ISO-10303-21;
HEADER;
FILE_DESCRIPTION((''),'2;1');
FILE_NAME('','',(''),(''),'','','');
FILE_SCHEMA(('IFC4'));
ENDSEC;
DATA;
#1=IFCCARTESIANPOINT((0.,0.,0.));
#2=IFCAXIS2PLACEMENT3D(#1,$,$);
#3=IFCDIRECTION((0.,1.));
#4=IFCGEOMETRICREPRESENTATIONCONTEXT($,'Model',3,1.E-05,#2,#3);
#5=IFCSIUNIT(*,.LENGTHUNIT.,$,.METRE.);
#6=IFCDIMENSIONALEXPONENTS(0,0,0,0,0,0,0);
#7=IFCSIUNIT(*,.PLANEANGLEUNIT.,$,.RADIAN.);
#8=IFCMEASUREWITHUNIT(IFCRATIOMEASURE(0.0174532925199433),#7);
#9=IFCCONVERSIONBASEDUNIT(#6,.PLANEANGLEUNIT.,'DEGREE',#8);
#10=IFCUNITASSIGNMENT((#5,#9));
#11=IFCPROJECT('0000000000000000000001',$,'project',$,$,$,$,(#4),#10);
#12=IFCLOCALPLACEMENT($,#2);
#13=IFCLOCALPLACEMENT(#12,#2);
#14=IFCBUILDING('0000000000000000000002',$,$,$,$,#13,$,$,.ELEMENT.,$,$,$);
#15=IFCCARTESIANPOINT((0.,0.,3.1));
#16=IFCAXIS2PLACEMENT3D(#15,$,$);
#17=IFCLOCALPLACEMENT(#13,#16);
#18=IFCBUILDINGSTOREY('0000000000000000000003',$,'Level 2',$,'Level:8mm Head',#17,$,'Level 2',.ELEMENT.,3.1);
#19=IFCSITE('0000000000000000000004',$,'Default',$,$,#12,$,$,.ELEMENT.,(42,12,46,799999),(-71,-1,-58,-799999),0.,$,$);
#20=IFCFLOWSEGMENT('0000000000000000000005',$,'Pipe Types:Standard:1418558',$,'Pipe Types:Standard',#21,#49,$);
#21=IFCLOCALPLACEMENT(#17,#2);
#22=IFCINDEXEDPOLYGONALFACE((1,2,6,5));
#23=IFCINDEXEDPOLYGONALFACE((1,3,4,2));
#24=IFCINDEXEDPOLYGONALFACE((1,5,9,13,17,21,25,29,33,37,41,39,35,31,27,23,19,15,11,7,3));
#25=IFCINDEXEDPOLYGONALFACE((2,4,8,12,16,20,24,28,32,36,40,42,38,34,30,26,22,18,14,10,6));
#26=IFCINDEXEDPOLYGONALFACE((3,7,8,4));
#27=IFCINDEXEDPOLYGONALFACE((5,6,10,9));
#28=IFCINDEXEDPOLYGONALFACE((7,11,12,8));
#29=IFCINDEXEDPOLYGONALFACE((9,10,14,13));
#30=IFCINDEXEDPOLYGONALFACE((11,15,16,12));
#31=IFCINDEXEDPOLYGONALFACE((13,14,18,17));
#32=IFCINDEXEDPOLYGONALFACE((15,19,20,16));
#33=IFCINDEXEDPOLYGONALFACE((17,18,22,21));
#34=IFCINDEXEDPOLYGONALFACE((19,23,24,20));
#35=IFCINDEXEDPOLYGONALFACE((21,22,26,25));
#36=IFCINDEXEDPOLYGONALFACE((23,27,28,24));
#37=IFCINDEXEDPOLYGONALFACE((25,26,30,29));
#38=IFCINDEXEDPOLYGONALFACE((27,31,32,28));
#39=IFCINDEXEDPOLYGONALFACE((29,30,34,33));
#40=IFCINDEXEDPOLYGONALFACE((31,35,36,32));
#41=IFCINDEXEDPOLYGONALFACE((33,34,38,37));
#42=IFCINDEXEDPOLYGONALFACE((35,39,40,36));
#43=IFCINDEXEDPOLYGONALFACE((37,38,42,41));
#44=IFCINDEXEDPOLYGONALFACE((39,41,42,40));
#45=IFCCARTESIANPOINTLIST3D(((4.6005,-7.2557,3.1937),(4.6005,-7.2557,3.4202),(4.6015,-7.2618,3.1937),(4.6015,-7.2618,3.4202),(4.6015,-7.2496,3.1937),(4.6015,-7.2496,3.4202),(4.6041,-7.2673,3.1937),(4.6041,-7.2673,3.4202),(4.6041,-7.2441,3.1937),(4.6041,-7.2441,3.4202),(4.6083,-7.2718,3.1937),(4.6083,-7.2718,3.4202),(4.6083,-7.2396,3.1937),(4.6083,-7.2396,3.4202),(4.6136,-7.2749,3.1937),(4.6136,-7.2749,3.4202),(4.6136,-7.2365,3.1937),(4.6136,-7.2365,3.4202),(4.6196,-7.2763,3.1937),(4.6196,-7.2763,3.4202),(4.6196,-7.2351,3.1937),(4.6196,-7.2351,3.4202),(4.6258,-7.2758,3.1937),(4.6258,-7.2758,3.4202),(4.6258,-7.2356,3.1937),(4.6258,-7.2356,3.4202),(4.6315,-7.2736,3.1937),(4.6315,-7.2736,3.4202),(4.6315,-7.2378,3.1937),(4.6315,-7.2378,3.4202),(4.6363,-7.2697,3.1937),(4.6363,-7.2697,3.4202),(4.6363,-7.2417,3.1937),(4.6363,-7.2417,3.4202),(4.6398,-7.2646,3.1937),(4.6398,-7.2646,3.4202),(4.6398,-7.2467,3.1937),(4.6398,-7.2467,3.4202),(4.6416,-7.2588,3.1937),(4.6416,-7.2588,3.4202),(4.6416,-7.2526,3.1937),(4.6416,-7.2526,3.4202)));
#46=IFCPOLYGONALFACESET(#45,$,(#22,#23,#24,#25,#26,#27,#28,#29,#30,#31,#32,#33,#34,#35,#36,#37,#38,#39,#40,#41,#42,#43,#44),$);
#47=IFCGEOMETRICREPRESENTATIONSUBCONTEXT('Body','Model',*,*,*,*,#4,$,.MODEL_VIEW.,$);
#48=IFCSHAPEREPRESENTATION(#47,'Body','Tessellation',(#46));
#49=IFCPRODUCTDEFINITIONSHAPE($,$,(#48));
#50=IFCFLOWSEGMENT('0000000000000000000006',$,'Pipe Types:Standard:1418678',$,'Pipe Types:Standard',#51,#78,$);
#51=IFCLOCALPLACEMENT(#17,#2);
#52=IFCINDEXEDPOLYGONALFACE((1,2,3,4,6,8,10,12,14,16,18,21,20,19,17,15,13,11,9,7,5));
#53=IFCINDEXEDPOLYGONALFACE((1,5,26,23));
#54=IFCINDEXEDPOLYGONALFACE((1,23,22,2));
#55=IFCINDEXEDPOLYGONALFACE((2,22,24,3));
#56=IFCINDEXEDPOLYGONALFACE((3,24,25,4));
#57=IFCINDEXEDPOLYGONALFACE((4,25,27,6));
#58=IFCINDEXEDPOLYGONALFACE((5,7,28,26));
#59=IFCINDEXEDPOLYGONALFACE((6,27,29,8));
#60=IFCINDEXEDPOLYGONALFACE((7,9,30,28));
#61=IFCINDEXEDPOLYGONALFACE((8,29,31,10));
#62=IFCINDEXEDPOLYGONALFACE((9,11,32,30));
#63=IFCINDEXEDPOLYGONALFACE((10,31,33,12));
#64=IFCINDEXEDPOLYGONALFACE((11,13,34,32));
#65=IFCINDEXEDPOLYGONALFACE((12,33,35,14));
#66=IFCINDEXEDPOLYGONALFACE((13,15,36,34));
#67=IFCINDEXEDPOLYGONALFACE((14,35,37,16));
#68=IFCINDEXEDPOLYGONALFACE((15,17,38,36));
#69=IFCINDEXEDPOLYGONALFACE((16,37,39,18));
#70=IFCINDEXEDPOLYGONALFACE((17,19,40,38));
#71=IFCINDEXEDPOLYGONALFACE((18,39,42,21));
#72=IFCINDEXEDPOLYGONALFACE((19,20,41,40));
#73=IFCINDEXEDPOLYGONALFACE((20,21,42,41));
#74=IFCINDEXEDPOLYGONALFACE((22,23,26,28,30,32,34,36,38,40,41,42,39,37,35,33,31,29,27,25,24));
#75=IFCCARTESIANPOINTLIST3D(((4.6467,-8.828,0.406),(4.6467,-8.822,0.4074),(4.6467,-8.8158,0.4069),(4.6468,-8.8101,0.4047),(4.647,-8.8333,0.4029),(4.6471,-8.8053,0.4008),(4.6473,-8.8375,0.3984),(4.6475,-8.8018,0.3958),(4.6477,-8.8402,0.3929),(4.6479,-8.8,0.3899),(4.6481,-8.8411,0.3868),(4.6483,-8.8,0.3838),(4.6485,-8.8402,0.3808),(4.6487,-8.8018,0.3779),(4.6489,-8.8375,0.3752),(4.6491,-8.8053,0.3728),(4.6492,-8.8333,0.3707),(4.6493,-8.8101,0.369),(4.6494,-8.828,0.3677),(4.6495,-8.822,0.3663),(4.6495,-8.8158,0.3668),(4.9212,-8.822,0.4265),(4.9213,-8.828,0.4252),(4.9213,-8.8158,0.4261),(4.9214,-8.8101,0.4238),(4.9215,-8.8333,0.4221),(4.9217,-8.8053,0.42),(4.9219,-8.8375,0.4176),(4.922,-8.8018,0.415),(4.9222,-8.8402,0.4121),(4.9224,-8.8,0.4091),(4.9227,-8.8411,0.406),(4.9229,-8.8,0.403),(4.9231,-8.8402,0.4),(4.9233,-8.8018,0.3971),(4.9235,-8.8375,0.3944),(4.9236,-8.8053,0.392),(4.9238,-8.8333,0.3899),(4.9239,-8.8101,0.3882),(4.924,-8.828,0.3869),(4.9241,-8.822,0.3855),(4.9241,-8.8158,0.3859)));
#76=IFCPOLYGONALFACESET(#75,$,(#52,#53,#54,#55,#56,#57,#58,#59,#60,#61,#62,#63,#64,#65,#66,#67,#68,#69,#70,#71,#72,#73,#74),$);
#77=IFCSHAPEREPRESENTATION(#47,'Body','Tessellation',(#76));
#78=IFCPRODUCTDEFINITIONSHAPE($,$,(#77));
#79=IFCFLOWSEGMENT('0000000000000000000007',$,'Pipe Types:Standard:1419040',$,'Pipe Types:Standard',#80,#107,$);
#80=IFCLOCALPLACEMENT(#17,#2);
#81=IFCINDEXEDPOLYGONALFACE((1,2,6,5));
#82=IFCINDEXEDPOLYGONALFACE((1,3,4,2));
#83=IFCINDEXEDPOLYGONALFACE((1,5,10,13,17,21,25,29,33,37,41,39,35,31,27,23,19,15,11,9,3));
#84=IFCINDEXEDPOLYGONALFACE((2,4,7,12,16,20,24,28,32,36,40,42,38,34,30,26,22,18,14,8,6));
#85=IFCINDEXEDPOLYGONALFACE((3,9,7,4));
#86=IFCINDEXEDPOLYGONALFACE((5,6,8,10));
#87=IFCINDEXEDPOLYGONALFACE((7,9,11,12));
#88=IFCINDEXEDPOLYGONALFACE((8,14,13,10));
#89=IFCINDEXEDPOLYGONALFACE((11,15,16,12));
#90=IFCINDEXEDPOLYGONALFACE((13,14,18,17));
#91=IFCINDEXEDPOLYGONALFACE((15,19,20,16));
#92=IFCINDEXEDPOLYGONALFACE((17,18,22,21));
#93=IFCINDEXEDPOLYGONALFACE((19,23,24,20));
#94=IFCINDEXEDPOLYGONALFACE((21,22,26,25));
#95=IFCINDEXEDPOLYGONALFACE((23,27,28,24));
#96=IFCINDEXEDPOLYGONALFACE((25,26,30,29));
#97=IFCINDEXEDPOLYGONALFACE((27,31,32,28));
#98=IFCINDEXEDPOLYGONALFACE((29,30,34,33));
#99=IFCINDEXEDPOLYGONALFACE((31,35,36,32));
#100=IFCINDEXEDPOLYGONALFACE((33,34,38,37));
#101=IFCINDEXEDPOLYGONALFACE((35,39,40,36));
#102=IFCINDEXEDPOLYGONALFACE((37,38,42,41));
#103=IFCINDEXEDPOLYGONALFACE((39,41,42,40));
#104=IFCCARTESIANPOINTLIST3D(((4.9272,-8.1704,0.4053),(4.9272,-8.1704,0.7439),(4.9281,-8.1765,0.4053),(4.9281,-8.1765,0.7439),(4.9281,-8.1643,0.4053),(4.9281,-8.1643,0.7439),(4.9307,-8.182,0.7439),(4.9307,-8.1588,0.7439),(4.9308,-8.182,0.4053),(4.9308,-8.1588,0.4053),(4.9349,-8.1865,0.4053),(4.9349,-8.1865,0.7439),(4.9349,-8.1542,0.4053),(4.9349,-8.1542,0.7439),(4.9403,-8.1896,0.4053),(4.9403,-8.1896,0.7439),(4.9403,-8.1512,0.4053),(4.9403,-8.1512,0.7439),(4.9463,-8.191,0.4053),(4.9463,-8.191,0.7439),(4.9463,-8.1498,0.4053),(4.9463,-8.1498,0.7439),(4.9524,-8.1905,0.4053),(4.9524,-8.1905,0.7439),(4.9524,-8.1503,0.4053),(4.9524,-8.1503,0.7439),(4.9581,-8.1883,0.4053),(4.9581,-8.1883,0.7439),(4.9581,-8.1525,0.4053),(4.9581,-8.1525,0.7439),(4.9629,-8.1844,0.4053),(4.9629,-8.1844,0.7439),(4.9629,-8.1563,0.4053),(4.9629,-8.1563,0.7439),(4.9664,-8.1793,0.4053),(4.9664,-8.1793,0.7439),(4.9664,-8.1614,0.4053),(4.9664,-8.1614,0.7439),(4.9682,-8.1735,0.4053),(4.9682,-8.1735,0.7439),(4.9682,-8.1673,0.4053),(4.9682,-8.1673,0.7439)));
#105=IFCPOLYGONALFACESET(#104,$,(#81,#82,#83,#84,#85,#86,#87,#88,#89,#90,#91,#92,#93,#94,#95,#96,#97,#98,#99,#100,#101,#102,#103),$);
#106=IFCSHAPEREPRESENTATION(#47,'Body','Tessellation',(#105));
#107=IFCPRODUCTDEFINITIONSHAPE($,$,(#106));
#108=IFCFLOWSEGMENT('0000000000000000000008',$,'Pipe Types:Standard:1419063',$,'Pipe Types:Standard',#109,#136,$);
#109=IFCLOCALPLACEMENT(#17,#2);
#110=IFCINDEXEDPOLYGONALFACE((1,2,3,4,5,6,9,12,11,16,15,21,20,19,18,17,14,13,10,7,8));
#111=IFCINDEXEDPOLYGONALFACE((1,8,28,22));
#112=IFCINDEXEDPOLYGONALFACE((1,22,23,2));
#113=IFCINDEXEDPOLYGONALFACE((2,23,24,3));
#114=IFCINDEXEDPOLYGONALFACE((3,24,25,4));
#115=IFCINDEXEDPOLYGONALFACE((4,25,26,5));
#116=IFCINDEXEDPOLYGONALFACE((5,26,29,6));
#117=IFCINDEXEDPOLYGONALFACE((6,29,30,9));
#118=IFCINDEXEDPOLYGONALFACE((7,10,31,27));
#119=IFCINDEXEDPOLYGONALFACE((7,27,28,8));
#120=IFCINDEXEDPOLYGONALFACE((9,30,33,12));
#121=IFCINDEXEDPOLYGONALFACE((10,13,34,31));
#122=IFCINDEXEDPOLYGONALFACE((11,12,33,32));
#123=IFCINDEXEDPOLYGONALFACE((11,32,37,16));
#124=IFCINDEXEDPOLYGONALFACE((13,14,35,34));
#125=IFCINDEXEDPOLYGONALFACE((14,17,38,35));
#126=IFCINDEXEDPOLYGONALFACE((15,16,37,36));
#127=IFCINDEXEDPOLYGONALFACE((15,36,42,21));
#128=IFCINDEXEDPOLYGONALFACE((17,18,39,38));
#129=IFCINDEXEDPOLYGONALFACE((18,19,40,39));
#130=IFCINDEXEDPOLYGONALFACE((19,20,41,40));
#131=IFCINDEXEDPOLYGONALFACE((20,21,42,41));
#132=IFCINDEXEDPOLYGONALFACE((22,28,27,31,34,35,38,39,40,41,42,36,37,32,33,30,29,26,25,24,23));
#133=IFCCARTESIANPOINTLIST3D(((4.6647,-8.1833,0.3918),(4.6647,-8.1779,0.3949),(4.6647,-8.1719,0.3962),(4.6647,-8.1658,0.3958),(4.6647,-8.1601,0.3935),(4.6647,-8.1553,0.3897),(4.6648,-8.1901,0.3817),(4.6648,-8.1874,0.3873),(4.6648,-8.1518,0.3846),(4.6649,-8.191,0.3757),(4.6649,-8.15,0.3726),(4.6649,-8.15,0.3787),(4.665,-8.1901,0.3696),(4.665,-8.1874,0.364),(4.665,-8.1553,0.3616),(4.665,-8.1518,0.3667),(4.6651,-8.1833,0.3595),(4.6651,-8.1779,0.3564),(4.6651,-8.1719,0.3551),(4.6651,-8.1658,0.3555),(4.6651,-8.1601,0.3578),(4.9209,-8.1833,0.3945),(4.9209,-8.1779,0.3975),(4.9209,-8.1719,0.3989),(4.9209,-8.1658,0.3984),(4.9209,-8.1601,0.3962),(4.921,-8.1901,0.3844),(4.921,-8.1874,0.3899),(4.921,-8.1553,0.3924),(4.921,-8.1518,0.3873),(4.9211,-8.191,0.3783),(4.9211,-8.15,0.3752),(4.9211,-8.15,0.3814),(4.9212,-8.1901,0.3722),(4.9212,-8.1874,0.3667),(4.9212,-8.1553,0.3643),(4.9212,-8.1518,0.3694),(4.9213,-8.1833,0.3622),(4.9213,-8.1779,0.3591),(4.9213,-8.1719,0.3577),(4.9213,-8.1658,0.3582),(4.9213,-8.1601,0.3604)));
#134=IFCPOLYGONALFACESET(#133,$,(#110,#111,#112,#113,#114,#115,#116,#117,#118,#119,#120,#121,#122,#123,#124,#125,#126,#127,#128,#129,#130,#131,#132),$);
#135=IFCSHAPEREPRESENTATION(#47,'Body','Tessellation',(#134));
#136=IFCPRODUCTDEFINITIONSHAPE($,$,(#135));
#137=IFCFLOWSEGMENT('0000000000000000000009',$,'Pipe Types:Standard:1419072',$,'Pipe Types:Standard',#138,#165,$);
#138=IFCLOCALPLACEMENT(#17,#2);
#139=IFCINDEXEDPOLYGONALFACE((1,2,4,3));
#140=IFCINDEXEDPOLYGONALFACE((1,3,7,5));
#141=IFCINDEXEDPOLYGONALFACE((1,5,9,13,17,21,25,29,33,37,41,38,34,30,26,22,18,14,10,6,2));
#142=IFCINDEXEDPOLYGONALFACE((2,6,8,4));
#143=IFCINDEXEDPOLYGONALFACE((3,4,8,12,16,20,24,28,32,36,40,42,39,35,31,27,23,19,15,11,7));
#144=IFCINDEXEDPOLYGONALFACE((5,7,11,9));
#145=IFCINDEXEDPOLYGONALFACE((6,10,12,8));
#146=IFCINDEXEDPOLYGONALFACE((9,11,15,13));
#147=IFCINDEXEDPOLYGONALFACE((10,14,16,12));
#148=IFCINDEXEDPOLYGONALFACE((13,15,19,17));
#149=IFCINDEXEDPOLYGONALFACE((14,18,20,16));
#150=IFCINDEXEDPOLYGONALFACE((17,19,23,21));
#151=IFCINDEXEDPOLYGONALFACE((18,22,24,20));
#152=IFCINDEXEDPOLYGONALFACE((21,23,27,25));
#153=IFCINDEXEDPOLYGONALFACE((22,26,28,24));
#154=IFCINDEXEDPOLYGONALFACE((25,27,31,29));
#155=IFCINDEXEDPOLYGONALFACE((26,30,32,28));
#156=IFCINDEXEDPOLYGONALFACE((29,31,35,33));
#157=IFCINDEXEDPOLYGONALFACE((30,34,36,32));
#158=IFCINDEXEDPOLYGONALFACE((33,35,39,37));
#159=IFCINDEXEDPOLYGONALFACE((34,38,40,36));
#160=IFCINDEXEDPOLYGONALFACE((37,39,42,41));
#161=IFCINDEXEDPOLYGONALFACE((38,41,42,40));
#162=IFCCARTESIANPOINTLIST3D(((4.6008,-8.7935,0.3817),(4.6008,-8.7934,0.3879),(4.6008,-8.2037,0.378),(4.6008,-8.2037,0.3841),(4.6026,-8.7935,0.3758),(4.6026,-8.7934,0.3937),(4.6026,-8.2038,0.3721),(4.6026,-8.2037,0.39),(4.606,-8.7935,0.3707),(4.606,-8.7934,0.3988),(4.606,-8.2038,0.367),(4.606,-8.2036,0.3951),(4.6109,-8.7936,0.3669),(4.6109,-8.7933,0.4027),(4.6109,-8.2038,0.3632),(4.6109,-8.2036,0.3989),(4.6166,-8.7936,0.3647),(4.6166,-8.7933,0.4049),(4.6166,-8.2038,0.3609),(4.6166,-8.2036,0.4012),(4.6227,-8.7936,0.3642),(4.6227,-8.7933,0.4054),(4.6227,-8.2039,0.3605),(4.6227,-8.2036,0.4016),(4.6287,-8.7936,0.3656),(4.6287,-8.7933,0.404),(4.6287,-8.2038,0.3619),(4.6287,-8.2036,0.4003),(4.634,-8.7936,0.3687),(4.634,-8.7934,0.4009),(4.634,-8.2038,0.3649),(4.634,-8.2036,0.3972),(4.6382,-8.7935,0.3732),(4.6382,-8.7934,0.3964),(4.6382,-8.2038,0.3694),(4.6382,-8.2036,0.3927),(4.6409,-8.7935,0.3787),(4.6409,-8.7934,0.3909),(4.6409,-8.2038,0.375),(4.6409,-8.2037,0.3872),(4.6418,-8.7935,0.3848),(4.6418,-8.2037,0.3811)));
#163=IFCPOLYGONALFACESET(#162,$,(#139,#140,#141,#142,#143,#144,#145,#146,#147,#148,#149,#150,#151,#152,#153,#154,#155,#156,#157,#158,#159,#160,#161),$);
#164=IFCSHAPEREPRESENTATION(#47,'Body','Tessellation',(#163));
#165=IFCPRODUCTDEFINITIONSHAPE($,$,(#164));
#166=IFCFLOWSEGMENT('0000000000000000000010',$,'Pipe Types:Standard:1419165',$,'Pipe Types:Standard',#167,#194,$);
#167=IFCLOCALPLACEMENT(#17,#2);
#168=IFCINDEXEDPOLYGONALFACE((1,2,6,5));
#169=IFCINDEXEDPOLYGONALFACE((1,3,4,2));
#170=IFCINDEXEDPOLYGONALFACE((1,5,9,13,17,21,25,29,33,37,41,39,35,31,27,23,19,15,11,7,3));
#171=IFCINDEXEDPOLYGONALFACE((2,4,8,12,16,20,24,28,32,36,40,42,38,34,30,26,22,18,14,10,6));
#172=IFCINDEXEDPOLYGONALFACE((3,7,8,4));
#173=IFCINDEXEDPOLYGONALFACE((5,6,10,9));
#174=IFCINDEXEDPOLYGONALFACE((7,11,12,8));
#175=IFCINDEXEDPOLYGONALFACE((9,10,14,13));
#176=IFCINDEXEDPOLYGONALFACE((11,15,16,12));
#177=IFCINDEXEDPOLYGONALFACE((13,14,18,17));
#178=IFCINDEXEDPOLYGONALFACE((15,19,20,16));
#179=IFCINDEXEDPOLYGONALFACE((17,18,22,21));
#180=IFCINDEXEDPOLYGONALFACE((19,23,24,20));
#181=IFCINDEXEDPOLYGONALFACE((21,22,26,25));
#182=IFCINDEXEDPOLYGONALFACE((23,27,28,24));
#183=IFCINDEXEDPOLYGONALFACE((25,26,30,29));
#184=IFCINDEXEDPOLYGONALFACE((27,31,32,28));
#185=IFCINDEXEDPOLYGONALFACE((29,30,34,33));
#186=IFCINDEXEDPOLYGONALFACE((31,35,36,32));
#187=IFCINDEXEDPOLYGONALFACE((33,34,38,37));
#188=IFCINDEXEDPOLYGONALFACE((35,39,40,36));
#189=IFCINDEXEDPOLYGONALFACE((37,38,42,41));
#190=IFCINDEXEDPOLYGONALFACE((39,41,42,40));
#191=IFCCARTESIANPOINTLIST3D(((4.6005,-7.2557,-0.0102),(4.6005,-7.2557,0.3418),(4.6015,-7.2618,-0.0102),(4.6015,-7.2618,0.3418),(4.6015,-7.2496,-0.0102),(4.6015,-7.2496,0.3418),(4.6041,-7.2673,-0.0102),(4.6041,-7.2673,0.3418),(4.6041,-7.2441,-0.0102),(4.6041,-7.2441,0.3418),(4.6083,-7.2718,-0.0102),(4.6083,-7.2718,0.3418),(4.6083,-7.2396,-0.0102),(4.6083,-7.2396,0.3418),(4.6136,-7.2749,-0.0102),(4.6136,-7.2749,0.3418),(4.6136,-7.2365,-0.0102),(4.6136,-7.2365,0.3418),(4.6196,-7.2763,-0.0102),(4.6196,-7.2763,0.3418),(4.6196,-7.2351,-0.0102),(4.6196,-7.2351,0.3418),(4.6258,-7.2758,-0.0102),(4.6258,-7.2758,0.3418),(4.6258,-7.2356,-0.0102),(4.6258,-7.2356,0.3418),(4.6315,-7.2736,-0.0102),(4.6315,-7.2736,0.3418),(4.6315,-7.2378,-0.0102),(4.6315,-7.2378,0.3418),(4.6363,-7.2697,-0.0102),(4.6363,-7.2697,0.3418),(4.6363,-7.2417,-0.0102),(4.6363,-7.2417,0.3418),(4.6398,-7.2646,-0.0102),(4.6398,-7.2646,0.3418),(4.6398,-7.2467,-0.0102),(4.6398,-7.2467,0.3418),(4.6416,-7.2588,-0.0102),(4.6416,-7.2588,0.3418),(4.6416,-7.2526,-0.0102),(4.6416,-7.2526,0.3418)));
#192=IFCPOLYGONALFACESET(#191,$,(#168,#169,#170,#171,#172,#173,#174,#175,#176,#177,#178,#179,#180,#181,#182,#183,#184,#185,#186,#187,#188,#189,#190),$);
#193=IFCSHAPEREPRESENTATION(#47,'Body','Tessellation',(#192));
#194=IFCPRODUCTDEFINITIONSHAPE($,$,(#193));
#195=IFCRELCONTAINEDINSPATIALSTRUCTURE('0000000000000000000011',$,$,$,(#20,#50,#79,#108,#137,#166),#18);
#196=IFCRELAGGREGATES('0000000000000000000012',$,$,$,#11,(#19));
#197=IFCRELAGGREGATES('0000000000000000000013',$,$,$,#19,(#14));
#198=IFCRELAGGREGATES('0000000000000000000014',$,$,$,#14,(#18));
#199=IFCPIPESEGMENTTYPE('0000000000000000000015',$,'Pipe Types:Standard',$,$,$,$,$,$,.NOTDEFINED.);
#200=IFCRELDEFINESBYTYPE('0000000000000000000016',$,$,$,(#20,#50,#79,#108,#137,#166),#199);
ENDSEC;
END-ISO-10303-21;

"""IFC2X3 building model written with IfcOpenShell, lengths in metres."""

from ifc_helpers import new_model, entity, si_unit, converted_unit, direction, frame, frame_2d, origin, origin_2d_with_axis, place, context, subcontext, project, spatial, circle, extrude, type_object, element, save


model = new_model("IFC2X3")

# Units and contexts
model_context = context("Model", 3, precision=1e-05, world=origin(), true_north=direction((0.0, 1.0)))
body_context = subcontext(model_context, "Body", "Model", "MODEL_VIEW")
ifc_project = project(units=[si_unit("LENGTHUNIT", "METRE"), converted_unit("PLANEANGLEUNIT", "DEGREE", entity("IfcRatioMeasure", 0.0174532925199433), si_unit("PLANEANGLEUNIT", "RADIAN"), dimensions=[0, 0, 0, 0, 0, 0, 0])], contexts=[model_context])

# Site, building, storey
site_placement = place(None, origin())
site = spatial("IfcSite", under=ifc_project, at=site_placement, Name="Default", CompositionType="ELEMENT", RefLatitude=(42, 12, 46, 799999), RefLongitude=(-71, -1, -58, -799999), RefElevation=0.0)
building_placement = place(site_placement, origin())
building = spatial("IfcBuilding", under=site, at=building_placement, CompositionType="ELEMENT")
storey_placement = place(building_placement, frame((0.0, 0.0, 3.1)))
storey = spatial("IfcBuildingStorey", under=building, at=storey_placement, Name="Level 2", ObjectType="Level:8mm Head", LongName="Level 2", CompositionType="ELEMENT", Elevation=3.1)

# Flow segments
pipe_segment_type = type_object("IfcPipeSegmentType", Name="Pipe Types:Standard", PredefinedType="NOTDEFINED")
flow_segment_1_placement = place(storey_placement, origin())
element("IfcFlowSegment", 1, at=flow_segment_1_placement, inside=storey, type_object=pipe_segment_type, Name="Pipe Types:Standard:1418558", ObjectType="Pipe Types:Standard", context=body_context, shape_type="SweptSolid", body=[
    extrude(circle(Radius=0.0206, at=origin_2d_with_axis()), frame((4.6212, -7.2557, 3.1937), z_axis=(0.0, 0.0, 1.0), x_axis=(-1.0, 0.0, 0.0)), (0.0, 0.0, 1.0), 0.2265),
])
flow_segment_2_placement = place(storey_placement, origin())
element("IfcFlowSegment", 2, at=flow_segment_2_placement, inside=storey, type_object=pipe_segment_type, Name="Pipe Types:Standard:1418678", ObjectType="Pipe Types:Standard", context=body_context, shape_type="SweptSolid", body=[
    extrude(circle(Radius=0.0206, at=origin_2d_with_axis()), frame((4.6481, -8.8204, 0.3868), z_axis=(0.997568, 0.0, 0.069693), x_axis=(0.0, -1.0, 0.0)), (0.0, 0.0, 1.0), 0.2752),
])
flow_segment_3_placement = place(storey_placement, origin())
element("IfcFlowSegment", 3, at=flow_segment_3_placement, inside=storey, type_object=pipe_segment_type, Name="Pipe Types:Standard:1419040", ObjectType="Pipe Types:Standard", context=body_context, shape_type="SweptSolid", body=[
    extrude(circle(Radius=0.0206, at=frame_2d((0.0, 0.0), x_axis=(1.0, 0.0))), frame((4.9478, -8.1704, 0.4053), z_axis=(-0.000016, 0.0, 1.0), x_axis=(-1.0, 0.0, -0.000016)), (0.0, 0.0, 1.0), 0.3385),
])
flow_segment_4_placement = place(storey_placement, origin())
element("IfcFlowSegment", 4, at=flow_segment_4_placement, inside=storey, type_object=pipe_segment_type, Name="Pipe Types:Standard:1419063", ObjectType="Pipe Types:Standard", context=body_context, shape_type="SweptSolid", body=[
    extrude(circle(Radius=0.0206, at=origin_2d_with_axis()), frame((4.6649, -8.1704, 0.3757), z_axis=(0.999946, 0.0, 0.010416), x_axis=(0.0, -1.0, 0.0)), (0.0, 0.0, 1.0), 0.2562),
])
flow_segment_5_placement = place(storey_placement, origin())
element("IfcFlowSegment", 5, at=flow_segment_5_placement, inside=storey, type_object=pipe_segment_type, Name="Pipe Types:Standard:1419072", ObjectType="Pipe Types:Standard", context=body_context, shape_type="SweptSolid", body=[
    extrude(circle(Radius=0.0206, at=frame_2d((0.0, 0.0), x_axis=(1.0, 0.0))), frame((4.6212, -8.7935, 0.3848), z_axis=(0.0, 0.99998, -0.006302), x_axis=(1.0, 0.0, 0.0)), (0.0, 0.0, 1.0), 0.5898),
])
flow_segment_6_placement = place(storey_placement, origin())
element("IfcFlowSegment", 6, at=flow_segment_6_placement, inside=storey, type_object=pipe_segment_type, Name="Pipe Types:Standard:1419165", ObjectType="Pipe Types:Standard", context=body_context, shape_type="SweptSolid", body=[
    extrude(circle(Radius=0.0206, at=origin_2d_with_axis()), frame((4.6212, -7.2557, -0.0102), z_axis=(0.0, 0.0, 1.0), x_axis=(-1.0, 0.0, 0.0)), (0.0, 0.0, 1.0), 0.3519),
])

save(model, "model.ifc")
